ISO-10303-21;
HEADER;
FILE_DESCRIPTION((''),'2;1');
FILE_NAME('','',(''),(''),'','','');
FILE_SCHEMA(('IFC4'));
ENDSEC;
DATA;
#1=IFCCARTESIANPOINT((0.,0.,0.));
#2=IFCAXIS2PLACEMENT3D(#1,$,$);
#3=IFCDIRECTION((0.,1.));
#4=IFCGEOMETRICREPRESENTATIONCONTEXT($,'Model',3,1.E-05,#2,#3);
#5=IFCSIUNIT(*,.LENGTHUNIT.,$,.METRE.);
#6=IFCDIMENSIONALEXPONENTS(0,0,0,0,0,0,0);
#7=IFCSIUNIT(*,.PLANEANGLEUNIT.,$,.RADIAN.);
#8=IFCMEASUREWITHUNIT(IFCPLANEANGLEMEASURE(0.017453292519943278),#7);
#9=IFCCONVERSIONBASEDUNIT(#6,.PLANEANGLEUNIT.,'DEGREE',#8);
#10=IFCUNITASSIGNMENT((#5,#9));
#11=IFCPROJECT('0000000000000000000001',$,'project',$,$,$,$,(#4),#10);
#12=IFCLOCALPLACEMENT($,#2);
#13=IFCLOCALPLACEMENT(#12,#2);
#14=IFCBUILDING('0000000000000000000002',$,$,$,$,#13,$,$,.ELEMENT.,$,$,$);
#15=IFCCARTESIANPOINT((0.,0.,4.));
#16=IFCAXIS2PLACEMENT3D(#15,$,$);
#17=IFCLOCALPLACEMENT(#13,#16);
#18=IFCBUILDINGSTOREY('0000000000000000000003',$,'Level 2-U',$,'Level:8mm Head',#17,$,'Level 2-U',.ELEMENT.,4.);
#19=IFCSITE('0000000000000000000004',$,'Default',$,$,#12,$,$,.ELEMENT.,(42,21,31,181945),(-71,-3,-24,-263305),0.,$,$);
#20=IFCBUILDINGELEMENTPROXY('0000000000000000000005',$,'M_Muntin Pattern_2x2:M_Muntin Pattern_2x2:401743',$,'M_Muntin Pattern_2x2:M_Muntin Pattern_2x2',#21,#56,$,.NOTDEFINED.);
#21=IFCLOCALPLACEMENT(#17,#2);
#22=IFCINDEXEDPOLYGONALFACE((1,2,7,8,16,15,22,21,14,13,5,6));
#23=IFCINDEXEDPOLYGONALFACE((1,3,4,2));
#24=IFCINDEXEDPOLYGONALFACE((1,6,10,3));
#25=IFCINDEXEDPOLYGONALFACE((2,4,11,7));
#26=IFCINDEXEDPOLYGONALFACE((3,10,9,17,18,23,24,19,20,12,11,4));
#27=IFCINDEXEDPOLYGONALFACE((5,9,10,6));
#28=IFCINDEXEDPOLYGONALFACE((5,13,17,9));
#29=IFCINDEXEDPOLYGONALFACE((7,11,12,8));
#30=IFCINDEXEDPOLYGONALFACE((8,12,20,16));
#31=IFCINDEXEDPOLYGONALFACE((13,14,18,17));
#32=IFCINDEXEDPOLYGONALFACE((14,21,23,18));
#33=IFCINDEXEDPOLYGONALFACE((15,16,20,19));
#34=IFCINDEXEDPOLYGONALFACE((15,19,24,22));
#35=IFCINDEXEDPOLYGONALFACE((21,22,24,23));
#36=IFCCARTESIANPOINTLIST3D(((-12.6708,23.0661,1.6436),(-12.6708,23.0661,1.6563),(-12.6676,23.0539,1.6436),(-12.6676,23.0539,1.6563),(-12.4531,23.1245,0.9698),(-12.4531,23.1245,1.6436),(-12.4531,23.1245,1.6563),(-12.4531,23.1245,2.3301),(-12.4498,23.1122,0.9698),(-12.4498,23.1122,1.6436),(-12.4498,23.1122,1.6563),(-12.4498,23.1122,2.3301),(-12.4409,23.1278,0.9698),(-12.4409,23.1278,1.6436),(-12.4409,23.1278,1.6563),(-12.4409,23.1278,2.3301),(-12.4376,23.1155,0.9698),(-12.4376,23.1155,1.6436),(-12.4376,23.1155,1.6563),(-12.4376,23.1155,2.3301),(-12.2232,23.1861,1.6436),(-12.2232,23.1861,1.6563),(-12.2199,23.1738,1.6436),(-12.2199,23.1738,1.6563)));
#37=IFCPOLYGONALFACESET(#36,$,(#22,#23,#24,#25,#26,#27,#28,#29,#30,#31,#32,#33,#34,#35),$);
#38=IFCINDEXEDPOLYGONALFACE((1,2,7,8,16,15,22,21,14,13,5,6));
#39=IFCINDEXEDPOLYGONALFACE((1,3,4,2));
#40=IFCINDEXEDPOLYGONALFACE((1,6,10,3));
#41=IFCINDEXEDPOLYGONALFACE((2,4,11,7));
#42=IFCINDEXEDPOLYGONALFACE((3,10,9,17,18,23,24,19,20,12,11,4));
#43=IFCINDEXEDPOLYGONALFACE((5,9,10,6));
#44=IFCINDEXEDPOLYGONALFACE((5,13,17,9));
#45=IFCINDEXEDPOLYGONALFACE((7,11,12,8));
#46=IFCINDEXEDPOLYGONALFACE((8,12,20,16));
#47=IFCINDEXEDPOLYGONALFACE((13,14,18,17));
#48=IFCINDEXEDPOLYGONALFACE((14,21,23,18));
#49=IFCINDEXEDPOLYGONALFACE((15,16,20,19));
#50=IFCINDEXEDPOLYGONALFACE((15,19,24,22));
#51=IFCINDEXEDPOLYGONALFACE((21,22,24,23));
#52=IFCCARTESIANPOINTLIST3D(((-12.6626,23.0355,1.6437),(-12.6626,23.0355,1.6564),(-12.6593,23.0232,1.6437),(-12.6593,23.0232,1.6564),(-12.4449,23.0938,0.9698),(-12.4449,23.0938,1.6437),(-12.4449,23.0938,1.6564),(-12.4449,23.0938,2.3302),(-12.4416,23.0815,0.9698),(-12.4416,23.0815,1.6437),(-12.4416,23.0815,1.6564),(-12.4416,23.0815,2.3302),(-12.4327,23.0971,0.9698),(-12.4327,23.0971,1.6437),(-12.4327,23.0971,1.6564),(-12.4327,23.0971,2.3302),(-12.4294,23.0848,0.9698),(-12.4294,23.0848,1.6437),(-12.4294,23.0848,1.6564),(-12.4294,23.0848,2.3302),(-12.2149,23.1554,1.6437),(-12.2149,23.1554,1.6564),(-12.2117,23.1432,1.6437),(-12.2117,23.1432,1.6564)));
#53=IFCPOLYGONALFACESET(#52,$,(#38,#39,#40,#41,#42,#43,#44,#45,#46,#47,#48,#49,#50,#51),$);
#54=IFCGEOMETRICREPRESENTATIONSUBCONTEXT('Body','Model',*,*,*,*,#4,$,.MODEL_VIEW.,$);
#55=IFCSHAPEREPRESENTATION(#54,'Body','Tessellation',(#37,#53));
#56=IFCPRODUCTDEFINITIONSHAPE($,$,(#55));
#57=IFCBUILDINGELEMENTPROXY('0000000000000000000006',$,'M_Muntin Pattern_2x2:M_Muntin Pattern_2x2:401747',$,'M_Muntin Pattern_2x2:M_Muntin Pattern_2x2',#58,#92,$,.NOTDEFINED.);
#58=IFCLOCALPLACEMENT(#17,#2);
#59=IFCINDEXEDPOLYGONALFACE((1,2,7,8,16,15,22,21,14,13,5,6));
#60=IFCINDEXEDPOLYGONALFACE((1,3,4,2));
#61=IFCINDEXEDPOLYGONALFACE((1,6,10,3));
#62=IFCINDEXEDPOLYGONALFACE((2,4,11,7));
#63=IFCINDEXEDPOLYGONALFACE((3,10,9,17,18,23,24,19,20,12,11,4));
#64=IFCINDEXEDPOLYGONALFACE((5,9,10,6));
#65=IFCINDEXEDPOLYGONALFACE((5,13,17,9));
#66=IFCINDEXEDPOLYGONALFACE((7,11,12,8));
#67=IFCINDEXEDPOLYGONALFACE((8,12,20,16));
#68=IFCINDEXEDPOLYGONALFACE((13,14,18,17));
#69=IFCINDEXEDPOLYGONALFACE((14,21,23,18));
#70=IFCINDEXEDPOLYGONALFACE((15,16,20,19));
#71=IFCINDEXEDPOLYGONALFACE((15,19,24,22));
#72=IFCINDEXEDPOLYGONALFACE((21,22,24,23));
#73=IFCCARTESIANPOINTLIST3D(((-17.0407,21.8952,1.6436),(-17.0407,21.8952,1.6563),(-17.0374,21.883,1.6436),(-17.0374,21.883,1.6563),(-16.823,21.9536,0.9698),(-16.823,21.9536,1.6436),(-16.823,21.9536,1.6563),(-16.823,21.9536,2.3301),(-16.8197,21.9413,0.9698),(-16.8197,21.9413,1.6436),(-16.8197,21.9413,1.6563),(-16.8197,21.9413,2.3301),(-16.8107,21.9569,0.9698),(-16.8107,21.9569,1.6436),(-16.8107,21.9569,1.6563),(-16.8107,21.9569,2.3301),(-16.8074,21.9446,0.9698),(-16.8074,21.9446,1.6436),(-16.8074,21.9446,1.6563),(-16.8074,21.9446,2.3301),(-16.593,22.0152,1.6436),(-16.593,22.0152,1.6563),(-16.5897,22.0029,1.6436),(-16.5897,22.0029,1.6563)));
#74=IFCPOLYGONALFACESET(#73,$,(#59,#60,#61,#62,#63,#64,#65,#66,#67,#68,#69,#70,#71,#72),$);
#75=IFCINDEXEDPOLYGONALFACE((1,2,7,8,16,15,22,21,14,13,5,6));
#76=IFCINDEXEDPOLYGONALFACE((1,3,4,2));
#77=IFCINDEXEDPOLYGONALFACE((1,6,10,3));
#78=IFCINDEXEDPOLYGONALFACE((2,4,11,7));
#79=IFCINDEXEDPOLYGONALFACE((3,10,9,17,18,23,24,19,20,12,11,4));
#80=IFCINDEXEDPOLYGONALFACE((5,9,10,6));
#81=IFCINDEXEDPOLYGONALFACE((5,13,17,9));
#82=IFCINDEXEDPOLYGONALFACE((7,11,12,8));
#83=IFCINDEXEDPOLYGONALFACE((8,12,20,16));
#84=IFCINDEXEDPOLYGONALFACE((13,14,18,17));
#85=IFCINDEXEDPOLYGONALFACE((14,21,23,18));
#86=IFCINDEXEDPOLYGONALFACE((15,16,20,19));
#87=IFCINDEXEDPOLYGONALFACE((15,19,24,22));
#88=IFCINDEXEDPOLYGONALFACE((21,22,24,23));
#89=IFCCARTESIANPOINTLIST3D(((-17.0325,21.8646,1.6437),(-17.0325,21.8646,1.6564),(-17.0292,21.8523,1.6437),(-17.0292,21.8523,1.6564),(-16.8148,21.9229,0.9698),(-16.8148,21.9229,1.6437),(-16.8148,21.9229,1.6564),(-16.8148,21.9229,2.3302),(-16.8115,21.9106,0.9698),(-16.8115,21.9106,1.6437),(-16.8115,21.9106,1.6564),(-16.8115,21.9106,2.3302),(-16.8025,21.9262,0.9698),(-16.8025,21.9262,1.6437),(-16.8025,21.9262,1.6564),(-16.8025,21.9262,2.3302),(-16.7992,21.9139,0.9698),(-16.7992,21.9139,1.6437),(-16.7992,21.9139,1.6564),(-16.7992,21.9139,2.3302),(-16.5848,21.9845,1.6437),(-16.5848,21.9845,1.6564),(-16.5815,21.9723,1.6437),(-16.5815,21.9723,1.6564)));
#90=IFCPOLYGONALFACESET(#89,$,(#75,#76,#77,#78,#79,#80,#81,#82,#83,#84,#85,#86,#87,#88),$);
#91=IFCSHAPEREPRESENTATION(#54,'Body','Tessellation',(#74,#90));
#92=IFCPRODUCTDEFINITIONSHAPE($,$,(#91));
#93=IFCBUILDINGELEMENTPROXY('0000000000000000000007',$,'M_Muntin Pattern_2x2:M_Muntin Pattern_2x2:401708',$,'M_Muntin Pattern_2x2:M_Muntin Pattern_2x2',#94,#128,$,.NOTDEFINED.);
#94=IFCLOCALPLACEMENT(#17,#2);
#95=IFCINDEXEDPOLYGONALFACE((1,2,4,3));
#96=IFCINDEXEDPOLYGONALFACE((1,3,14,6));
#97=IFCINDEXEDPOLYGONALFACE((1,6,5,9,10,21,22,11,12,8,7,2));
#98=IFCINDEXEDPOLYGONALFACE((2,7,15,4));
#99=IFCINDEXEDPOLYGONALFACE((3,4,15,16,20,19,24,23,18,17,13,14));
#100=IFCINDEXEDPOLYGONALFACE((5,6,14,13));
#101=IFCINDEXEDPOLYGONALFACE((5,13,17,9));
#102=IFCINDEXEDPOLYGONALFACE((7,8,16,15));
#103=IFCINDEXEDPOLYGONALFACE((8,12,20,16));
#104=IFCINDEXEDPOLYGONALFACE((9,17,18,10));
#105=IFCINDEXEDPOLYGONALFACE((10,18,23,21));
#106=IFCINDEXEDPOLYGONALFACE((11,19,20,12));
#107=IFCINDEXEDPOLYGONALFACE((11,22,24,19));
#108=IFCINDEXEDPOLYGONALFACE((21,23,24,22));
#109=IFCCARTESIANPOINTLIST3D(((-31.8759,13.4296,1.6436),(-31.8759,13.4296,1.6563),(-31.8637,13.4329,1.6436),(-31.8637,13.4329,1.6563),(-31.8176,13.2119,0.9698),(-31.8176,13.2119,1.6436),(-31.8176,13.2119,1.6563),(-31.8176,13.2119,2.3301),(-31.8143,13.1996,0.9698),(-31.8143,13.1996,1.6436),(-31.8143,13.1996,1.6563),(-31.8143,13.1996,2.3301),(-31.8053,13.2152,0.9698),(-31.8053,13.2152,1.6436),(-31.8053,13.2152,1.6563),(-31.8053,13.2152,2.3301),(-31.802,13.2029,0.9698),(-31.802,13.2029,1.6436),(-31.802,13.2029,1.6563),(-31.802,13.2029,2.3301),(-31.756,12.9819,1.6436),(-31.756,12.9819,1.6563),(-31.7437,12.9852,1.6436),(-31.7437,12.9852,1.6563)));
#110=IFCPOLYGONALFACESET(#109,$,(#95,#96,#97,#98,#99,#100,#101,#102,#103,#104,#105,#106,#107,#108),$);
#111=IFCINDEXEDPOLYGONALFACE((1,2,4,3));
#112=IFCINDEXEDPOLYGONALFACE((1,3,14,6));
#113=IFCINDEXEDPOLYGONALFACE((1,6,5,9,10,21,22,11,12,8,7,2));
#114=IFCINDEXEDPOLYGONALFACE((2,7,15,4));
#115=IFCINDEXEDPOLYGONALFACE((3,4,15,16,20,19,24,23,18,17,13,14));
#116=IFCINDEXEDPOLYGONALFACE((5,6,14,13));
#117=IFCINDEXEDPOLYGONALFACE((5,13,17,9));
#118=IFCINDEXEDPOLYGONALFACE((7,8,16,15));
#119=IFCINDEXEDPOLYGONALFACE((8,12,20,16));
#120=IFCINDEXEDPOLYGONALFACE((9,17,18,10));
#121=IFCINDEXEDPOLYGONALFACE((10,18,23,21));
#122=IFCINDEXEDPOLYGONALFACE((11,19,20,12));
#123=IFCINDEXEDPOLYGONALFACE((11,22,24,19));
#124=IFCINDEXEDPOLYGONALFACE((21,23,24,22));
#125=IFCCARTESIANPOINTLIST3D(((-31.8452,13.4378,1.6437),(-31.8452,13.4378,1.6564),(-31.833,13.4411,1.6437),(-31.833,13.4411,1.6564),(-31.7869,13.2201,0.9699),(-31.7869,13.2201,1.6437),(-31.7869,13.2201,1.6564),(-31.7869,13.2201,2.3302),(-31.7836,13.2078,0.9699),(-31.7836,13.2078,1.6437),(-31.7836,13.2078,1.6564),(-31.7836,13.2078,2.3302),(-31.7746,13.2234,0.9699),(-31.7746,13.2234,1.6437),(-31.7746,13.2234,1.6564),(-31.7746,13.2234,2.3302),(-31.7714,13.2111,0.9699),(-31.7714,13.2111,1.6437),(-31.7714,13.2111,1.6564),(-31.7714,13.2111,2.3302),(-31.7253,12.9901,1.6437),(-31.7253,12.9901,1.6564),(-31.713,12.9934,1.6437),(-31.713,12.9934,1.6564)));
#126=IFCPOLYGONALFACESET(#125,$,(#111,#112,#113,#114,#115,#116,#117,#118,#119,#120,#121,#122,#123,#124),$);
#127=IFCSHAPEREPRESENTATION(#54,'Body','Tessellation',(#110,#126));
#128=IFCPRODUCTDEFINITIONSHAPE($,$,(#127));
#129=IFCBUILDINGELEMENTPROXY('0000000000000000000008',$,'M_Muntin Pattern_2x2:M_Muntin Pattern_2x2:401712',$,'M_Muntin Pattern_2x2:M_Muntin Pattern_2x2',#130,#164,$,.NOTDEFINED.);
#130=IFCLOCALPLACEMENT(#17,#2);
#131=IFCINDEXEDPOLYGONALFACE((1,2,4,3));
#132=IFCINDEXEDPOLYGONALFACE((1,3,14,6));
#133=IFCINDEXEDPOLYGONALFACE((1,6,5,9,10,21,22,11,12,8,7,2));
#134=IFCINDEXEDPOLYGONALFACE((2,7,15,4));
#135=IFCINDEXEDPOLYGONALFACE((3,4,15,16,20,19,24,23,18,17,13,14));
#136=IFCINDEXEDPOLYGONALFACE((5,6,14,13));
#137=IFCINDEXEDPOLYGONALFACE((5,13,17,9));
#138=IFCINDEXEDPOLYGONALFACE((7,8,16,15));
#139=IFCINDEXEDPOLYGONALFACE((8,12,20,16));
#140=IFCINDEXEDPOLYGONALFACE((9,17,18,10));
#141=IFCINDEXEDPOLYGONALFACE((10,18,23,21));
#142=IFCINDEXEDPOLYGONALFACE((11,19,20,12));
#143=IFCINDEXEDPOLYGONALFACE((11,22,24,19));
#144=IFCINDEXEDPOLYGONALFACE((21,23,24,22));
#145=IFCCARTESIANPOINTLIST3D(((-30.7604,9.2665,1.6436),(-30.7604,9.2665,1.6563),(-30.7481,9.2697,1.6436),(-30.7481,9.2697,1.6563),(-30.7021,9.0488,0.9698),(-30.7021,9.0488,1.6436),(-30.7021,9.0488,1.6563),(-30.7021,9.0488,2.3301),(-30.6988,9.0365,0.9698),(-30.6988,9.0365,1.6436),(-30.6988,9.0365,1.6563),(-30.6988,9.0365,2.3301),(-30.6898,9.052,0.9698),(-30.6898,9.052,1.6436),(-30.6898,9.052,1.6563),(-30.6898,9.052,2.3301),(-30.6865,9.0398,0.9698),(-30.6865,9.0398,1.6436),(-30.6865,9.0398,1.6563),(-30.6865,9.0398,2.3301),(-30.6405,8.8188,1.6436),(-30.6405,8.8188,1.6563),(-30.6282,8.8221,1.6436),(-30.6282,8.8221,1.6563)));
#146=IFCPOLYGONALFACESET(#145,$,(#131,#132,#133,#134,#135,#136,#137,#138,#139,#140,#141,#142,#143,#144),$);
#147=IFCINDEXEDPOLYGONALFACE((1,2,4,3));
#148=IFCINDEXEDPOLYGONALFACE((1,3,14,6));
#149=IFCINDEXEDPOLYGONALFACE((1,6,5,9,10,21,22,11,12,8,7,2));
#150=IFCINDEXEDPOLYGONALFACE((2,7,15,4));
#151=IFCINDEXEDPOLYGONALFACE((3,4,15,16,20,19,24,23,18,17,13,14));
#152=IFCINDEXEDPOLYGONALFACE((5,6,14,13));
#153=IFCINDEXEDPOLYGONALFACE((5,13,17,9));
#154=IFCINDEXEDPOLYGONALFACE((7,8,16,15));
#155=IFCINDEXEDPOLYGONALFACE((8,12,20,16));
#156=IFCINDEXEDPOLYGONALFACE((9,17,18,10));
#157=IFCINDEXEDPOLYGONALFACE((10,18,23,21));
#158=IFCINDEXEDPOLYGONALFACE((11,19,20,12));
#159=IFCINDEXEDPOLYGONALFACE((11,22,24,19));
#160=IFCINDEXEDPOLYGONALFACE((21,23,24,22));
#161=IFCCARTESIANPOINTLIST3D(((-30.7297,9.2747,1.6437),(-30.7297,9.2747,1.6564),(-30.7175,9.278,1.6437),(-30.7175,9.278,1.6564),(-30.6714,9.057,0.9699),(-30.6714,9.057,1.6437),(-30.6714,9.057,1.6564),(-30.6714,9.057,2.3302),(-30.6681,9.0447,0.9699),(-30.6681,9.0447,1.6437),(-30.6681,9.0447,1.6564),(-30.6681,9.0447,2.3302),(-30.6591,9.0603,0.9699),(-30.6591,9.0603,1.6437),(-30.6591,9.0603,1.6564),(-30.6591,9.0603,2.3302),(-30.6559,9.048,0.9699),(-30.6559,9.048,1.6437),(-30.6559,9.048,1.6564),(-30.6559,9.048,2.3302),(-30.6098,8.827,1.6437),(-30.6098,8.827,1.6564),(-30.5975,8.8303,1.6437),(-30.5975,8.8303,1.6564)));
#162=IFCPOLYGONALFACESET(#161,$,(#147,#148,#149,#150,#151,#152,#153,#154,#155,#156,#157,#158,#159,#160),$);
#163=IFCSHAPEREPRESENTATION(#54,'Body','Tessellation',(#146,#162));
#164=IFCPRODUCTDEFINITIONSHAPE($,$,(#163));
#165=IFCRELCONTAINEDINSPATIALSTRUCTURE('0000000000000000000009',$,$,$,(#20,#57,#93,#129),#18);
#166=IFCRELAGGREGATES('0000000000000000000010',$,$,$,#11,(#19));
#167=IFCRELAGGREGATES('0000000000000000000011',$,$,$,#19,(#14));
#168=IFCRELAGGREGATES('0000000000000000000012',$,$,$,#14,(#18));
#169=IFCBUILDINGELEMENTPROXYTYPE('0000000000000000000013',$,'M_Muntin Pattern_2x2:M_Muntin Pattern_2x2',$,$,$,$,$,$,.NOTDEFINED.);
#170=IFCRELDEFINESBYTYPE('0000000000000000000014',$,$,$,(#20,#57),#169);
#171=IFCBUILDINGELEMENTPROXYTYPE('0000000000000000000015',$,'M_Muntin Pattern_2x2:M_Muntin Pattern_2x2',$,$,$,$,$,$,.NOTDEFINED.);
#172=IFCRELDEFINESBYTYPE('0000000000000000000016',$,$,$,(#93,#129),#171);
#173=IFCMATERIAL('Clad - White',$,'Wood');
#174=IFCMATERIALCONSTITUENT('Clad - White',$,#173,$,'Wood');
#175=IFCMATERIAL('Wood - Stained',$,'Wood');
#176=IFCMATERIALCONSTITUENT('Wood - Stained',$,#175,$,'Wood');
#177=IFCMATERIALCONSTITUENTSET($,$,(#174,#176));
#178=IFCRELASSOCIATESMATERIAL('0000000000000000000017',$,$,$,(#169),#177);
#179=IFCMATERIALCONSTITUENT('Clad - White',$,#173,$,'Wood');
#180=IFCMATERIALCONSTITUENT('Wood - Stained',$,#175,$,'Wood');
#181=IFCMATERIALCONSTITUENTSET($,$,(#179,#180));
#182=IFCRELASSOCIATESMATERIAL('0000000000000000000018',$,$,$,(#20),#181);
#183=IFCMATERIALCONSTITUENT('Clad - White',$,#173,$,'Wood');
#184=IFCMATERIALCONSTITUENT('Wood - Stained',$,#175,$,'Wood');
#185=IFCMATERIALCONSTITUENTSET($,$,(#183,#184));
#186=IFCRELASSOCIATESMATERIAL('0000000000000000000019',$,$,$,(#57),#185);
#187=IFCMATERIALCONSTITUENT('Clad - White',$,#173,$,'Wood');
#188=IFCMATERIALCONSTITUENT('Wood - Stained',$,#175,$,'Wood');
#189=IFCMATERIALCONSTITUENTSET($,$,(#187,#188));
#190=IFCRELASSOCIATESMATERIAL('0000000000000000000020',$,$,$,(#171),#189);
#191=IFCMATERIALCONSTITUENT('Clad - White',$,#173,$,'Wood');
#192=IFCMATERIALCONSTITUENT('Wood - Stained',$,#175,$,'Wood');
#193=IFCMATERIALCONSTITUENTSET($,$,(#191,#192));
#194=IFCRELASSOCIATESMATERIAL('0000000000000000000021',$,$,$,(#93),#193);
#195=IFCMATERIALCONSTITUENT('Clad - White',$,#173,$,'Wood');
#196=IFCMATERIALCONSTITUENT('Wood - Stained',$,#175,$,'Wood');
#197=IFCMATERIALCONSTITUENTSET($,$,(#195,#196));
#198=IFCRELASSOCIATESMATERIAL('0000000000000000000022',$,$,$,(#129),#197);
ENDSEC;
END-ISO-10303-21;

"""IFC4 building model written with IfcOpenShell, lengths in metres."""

from ifc_helpers import new_model, entity, si_unit, converted_unit, direction, frame, origin, place, context, subcontext, project, spatial, polyline, outline, extrude, source, transform, mapped, material, constituent, constituent_set, type_object, type_shapes, element, save


model = new_model("IFC4")

# Units and contexts
model_context = context("Model", 3, precision=1e-05, world=origin(), true_north=direction((0.0, 1.0)))
body_context = subcontext(model_context, "Body", "Model", "MODEL_VIEW")
ifc_project = project(units=[si_unit("LENGTHUNIT", "METRE"), converted_unit("PLANEANGLEUNIT", "DEGREE", entity("IfcPlaneAngleMeasure", 0.017453292519943278), si_unit("PLANEANGLEUNIT", "RADIAN"), dimensions=[0, 0, 0, 0, 0, 0, 0])], contexts=[model_context])

# Site, building, storey
site_placement = place(None, origin())
site = spatial("IfcSite", under=ifc_project, at=site_placement, Name="Default", CompositionType="ELEMENT", RefLatitude=(42, 21, 31, 181945), RefLongitude=(-71, -3, -24, -263305), RefElevation=0.0)
building_placement = place(site_placement, origin())
building = spatial("IfcBuilding", under=site, at=building_placement, CompositionType="ELEMENT")
storey_placement = place(building_placement, frame((0.0, 0.0, 4.0)))
storey = spatial("IfcBuildingStorey", under=building, at=storey_placement, Name="Level 2-U", ObjectType="Level:8mm Head", LongName="Level 2-U", CompositionType="ELEMENT", Elevation=4.0)

# Building element proxies
ifc_material_1 = material(Name="Clad - White", Category="Wood")
ifc_material_2 = material(Name="Wood - Stained", Category="Wood")
ifc_constituent_1 = constituent(ifc_material_1, Name="Clad - White", Category="Wood")
ifc_constituent_2 = constituent(ifc_material_2, Name="Wood - Stained", Category="Wood")
ifc_constituent_set_1 = constituent_set(constituents=[ifc_constituent_1, ifc_constituent_2])
building_element_proxy_type_1 = type_object("IfcBuildingElementProxyType", Name="M_Muntin Pattern_2x2:M_Muntin Pattern_2x2", PredefinedType="NOTDEFINED", material=ifc_constituent_set_1)
shared_shape_1 = source(origin(), body_context, "Body", "SweptSolid", [
    extrude(outline(polyline([(0.0064, -0.0064), (0.6801, -0.0064), (0.6801, 0.0063), (0.0064, 0.0063), (0.0064, 0.2317), (-0.0063, 0.2317), (-0.0063, 0.0063), (-0.6802, 0.0063), (-0.6802, -0.0064), (-0.0063, -0.0064), (-0.0063, -0.2317), (0.0064, -0.2317), (0.0064, -0.0064)])), frame((0.0, 0.0095, 0.6801), z_axis=(0.0, 1.0, 0.0), x_axis=(0.0, 0.0, 1.0)), (0.0, 0.0, 1.0), 0.0127),
    extrude(outline(polyline([(0.0064, -0.0064), (0.6802, -0.0064), (0.6802, 0.0063), (0.0064, 0.0063), (0.0064, 0.2317), (-0.0063, 0.2317), (-0.0063, 0.0063), (-0.6802, 0.0063), (-0.6802, -0.0064), (-0.0063, -0.0064), (-0.0063, -0.2317), (0.0064, -0.2317), (0.0064, -0.0064)])), frame((0.0, -0.0222, 0.6802), z_axis=(0.0, 1.0, 0.0), x_axis=(0.0, 0.0, 1.0)), (0.0, 0.0, 1.0), 0.0127),
])
type_shapes(building_element_proxy_type_1, [shared_shape_1])
ifc_constituent_3 = constituent(ifc_material_1, Name="Clad - White", Category="Wood")
ifc_constituent_4 = constituent(ifc_material_2, Name="Wood - Stained", Category="Wood")
ifc_constituent_set_2 = constituent_set(constituents=[ifc_constituent_3, ifc_constituent_4])
proxy_1_placement = place(storey_placement, frame((-12.4412, 23.1047, 0.9698), z_axis=(0.0, 0.0, 1.0), x_axis=(0.965926, 0.258819, 0.0)))
element("IfcBuildingElementProxy", 1, at=proxy_1_placement, inside=storey, type_object=building_element_proxy_type_1, material=ifc_constituent_set_2, Name="M_Muntin Pattern_2x2:M_Muntin Pattern_2x2:401743", ObjectType="M_Muntin Pattern_2x2:M_Muntin Pattern_2x2", PredefinedType="NOTDEFINED", context=body_context, shape_type="MappedRepresentation", body=[
    mapped(shared_shape_1, transform((0.0, 0.0, 0.0), scale=1.0)),
])
ifc_constituent_5 = constituent(ifc_material_1, Name="Clad - White", Category="Wood")
ifc_constituent_6 = constituent(ifc_material_2, Name="Wood - Stained", Category="Wood")
ifc_constituent_set_3 = constituent_set(constituents=[ifc_constituent_5, ifc_constituent_6])
proxy_2_placement = place(storey_placement, frame((-16.8111, 21.9338, 0.9698), z_axis=(0.0, 0.0, 1.0), x_axis=(0.965926, 0.258819, 0.0)))
element("IfcBuildingElementProxy", 2, at=proxy_2_placement, inside=storey, type_object=building_element_proxy_type_1, material=ifc_constituent_set_3, Name="M_Muntin Pattern_2x2:M_Muntin Pattern_2x2:401747", ObjectType="M_Muntin Pattern_2x2:M_Muntin Pattern_2x2", PredefinedType="NOTDEFINED", context=body_context, shape_type="MappedRepresentation", body=[
    mapped(shared_shape_1, transform((0.0, 0.0, 0.0), scale=1.0)),
])
ifc_constituent_7 = constituent(ifc_material_1, Name="Clad - White", Category="Wood")
ifc_constituent_8 = constituent(ifc_material_2, Name="Wood - Stained", Category="Wood")
ifc_constituent_set_4 = constituent_set(constituents=[ifc_constituent_7, ifc_constituent_8])
ifc_constituent_9 = constituent(ifc_material_1, Name="Clad - White", Category="Wood")
ifc_constituent_10 = constituent(ifc_material_2, Name="Wood - Stained", Category="Wood")
ifc_constituent_set_5 = constituent_set(constituents=[ifc_constituent_9, ifc_constituent_10])
building_element_proxy_type_2 = type_object("IfcBuildingElementProxyType", Name="M_Muntin Pattern_2x2:M_Muntin Pattern_2x2", PredefinedType="NOTDEFINED", material=ifc_constituent_set_5)
shared_shape_2 = source(origin(), body_context, "Body", "SweptSolid", [
    extrude(outline(polyline([(0.0064, -0.0064), (0.6801, -0.0064), (0.6801, 0.0063), (0.0064, 0.0063), (0.0064, 0.2317), (-0.0063, 0.2317), (-0.0063, 0.0063), (-0.6802, 0.0063), (-0.6802, -0.0064), (-0.0063, -0.0064), (-0.0063, -0.2317), (0.0064, -0.2317), (0.0064, -0.0064)])), frame((0.0, -0.0222, 0.6801), z_axis=(0.0, 1.0, 0.0), x_axis=(0.0, 0.0, 1.0)), (0.0, 0.0, 1.0), 0.0127),
    extrude(outline(polyline([(0.0064, -0.0064), (0.6802, -0.0064), (0.6802, 0.0063), (0.0064, 0.0063), (0.0064, 0.2317), (-0.0063, 0.2317), (-0.0063, 0.0063), (-0.6802, 0.0063), (-0.6802, -0.0064), (-0.0063, -0.0064), (-0.0063, -0.2317), (0.0064, -0.2317), (0.0064, -0.0064)])), frame((0.0, 0.0095, 0.6802), z_axis=(0.0, 1.0, 0.0), x_axis=(0.0, 0.0, 1.0)), (0.0, 0.0, 1.0), 0.0127),
])
type_shapes(building_element_proxy_type_2, [shared_shape_2])
proxy_3_placement = place(storey_placement, frame((-31.7945, 13.2115, 0.9699), z_axis=(0.0, 0.0, 1.0), x_axis=(0.258819, -0.965926, 0.0)))
element("IfcBuildingElementProxy", 3, at=proxy_3_placement, inside=storey, type_object=building_element_proxy_type_2, material=ifc_constituent_set_4, Name="M_Muntin Pattern_2x2:M_Muntin Pattern_2x2:401708", ObjectType="M_Muntin Pattern_2x2:M_Muntin Pattern_2x2", PredefinedType="NOTDEFINED", context=body_context, shape_type="MappedRepresentation", body=[
    mapped(shared_shape_2, transform((0.0, 0.0, 0.0), scale=1.0)),
])
ifc_constituent_11 = constituent(ifc_material_1, Name="Clad - White", Category="Wood")
ifc_constituent_12 = constituent(ifc_material_2, Name="Wood - Stained", Category="Wood")
ifc_constituent_set_6 = constituent_set(constituents=[ifc_constituent_11, ifc_constituent_12])
proxy_4_placement = place(storey_placement, frame((-30.679, 9.0484, 0.9699), z_axis=(0.0, 0.0, 1.0), x_axis=(0.258819, -0.965926, 0.0)))
element("IfcBuildingElementProxy", 4, at=proxy_4_placement, inside=storey, type_object=building_element_proxy_type_2, material=ifc_constituent_set_6, Name="M_Muntin Pattern_2x2:M_Muntin Pattern_2x2:401712", ObjectType="M_Muntin Pattern_2x2:M_Muntin Pattern_2x2", PredefinedType="NOTDEFINED", context=body_context, shape_type="MappedRepresentation", body=[
    mapped(shared_shape_2, transform((0.0, 0.0, 0.0), scale=1.0)),
])

save(model, "model.ifc")
